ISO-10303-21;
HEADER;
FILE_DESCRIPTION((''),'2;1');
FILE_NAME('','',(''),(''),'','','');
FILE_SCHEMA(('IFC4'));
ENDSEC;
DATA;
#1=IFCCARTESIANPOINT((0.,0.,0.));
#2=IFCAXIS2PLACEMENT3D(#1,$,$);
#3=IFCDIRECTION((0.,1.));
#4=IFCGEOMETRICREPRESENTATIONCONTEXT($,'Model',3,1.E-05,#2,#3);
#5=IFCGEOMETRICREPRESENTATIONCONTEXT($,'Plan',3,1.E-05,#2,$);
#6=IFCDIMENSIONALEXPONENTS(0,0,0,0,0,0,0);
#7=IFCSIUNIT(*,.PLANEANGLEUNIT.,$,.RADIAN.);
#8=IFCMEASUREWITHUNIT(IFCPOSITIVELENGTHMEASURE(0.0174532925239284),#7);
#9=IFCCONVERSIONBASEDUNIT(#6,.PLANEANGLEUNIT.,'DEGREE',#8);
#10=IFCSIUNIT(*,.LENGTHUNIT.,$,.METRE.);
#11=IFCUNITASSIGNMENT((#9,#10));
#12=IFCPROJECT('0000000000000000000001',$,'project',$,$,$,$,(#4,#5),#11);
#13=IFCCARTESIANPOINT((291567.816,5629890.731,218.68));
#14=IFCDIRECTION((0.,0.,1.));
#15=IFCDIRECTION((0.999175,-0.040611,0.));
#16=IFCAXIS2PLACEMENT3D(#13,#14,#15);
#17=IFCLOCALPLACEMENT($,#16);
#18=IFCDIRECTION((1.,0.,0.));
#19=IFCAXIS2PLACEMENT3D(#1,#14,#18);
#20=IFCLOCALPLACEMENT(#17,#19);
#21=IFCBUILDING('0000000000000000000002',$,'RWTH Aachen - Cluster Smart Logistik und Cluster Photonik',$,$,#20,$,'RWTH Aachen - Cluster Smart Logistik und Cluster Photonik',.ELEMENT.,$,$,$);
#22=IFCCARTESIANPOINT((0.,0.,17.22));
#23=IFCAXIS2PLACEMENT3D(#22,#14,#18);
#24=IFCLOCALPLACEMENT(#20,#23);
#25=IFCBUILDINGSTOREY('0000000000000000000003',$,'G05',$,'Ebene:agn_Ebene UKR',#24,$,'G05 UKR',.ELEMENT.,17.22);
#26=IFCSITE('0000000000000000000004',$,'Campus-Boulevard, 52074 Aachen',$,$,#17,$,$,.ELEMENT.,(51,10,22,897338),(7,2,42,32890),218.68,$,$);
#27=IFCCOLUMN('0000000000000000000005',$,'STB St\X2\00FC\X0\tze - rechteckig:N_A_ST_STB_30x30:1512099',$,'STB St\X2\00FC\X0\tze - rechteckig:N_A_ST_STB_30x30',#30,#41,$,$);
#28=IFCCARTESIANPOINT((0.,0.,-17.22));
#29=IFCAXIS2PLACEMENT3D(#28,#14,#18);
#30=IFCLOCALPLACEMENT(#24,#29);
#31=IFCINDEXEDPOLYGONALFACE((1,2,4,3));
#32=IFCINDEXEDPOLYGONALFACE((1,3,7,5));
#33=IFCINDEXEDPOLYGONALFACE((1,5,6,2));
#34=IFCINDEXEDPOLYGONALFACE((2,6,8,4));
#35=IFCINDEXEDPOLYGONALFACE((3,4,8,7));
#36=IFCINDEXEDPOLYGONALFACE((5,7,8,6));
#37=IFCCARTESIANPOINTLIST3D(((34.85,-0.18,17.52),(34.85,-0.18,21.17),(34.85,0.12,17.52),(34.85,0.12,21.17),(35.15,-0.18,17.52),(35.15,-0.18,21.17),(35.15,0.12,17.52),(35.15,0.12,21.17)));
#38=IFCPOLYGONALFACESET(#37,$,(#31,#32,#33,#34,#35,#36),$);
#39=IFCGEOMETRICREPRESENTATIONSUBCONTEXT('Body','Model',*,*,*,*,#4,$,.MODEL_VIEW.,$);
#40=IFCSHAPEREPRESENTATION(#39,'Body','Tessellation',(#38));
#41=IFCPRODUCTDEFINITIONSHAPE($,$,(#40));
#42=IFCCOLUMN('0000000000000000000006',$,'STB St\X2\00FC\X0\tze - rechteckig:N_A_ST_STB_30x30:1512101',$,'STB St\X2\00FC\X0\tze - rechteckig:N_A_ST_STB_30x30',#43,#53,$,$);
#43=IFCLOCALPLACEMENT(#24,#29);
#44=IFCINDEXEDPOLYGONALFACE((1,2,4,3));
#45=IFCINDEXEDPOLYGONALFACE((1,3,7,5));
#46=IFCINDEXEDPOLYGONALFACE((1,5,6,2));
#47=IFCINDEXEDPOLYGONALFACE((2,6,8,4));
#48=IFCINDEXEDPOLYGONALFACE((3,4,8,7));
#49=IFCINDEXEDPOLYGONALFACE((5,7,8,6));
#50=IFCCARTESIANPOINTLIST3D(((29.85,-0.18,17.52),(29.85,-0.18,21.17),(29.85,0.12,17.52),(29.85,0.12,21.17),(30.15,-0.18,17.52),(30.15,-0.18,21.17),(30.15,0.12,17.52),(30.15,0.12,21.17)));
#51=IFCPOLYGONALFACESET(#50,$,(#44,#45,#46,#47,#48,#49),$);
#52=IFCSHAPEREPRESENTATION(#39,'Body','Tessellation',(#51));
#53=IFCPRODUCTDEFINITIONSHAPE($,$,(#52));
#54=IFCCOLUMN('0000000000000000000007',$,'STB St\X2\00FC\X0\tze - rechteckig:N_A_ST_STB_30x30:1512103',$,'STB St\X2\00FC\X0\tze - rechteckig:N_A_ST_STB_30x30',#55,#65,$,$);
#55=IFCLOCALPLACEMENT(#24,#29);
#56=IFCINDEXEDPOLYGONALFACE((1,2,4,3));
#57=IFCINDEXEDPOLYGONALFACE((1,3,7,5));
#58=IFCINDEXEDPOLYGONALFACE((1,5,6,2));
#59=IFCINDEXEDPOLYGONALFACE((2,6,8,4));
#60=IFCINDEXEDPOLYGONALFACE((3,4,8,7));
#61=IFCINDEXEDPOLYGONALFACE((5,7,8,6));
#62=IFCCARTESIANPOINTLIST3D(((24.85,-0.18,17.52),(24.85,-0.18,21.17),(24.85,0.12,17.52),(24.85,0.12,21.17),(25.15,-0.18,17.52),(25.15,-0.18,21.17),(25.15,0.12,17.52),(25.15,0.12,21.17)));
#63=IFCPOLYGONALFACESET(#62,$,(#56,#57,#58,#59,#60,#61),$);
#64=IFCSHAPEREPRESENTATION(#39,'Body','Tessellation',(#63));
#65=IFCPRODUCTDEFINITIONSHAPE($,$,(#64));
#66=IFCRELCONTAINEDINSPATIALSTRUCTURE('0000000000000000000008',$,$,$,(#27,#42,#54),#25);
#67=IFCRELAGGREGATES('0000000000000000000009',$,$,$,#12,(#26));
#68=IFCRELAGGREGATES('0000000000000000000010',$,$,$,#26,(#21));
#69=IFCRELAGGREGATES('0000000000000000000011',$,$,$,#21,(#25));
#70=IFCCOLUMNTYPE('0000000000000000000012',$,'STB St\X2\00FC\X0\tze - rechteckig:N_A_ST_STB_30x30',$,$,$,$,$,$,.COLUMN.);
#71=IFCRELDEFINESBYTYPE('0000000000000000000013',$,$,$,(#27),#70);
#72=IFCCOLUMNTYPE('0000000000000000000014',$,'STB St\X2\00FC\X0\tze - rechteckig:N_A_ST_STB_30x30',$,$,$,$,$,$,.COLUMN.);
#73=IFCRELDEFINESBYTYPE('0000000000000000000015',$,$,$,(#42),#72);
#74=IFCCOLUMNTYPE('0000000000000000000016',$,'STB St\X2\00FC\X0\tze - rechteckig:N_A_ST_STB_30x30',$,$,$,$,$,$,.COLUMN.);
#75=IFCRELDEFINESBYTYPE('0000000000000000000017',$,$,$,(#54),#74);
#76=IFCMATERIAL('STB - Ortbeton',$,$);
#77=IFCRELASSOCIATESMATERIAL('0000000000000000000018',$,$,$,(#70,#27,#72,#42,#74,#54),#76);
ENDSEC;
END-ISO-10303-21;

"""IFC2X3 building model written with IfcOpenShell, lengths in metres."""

from ifc_helpers import new_model, entity, si_unit, converted_unit, direction, frame, origin, origin_with_axes, origin_2d_with_axis, place, context, subcontext, project, spatial, rectangle, extrude, source, transform, mapped, material, type_object, element, save


model = new_model("IFC2X3")

# Units and contexts
model_context = context("Model", 3, precision=1e-05, world=origin(), true_north=direction((0.0, 1.0)))
plan_context = context("Plan", 3, precision=1e-05, world=origin())
body_context = subcontext(model_context, "Body", "Model", "MODEL_VIEW")
ifc_project = project(units=[converted_unit("PLANEANGLEUNIT", "DEGREE", entity("IfcPositiveLengthMeasure", 0.0174532925239284), si_unit("PLANEANGLEUNIT", "RADIAN"), dimensions=[0, 0, 0, 0, 0, 0, 0]), si_unit("LENGTHUNIT", "METRE")], contexts=[model_context, plan_context])

# Site, building, storey
site_placement = place(None, frame((291567.816, 5629890.731, 218.68), z_axis=(0.0, 0.0, 1.0), x_axis=(0.999175, -0.040611, 0.0)))
site = spatial("IfcSite", under=ifc_project, at=site_placement, Name="Campus-Boulevard, 52074 Aachen", CompositionType="ELEMENT", RefLatitude=(51, 10, 22, 897338), RefLongitude=(7, 2, 42, 32890), RefElevation=218.68)
building_placement = place(site_placement, origin_with_axes())
building = spatial("IfcBuilding", under=site, at=building_placement, Name="RWTH Aachen - Cluster Smart Logistik und Cluster Photonik", LongName="RWTH Aachen - Cluster Smart Logistik und Cluster Photonik", CompositionType="ELEMENT")
storey_placement = place(building_placement, frame((0.0, 0.0, 17.22), z_axis=(0.0, 0.0, 1.0), x_axis=(1.0, 0.0, 0.0)))
storey = spatial("IfcBuildingStorey", under=building, at=storey_placement, Name="G05", ObjectType="Ebene:agn_Ebene UKR", LongName="G05 UKR", CompositionType="ELEMENT", Elevation=17.22)

# Columns
ifc_material = material(Name="STB - Ortbeton")
column_type_1 = type_object("IfcColumnType", Name="STB Stütze - rechteckig:N_A_ST_STB_30x30", PredefinedType="COLUMN", material=ifc_material)
shared_shape_1 = source(origin(), body_context, "Body", "SweptSolid", [
    extrude(rectangle(XDim=0.3, YDim=0.3, at=origin_2d_with_axis()), frame((35.0, -0.03, 17.52), z_axis=(0.0, 0.0, 1.0), x_axis=(0.0, -1.0, 0.0)), (0.0, 0.0, 1.0), 3.65),
])
column_1_placement = place(storey_placement, frame((0.0, 0.0, -17.22), z_axis=(0.0, 0.0, 1.0), x_axis=(1.0, 0.0, 0.0)))
element("IfcColumn", 1, at=column_1_placement, inside=storey, type_object=column_type_1, material=ifc_material, Name="STB Stütze - rechteckig:N_A_ST_STB_30x30:1512099", ObjectType="STB Stütze - rechteckig:N_A_ST_STB_30x30", context=body_context, shape_type="MappedRepresentation", body=[
    mapped(shared_shape_1, transform((0.0, 0.0, 0.0), scale=1.0)),
])
column_type_2 = type_object("IfcColumnType", Name="STB Stütze - rechteckig:N_A_ST_STB_30x30", PredefinedType="COLUMN", material=ifc_material)
shared_shape_2 = source(origin(), body_context, "Body", "SweptSolid", [
    extrude(rectangle(XDim=0.3, YDim=0.3, at=origin_2d_with_axis()), frame((30.0, -0.03, 17.52), z_axis=(0.0, 0.0, 1.0), x_axis=(0.0, -1.0, 0.0)), (0.0, 0.0, 1.0), 3.65),
])
column_2_placement = place(storey_placement, frame((0.0, 0.0, -17.22), z_axis=(0.0, 0.0, 1.0), x_axis=(1.0, 0.0, 0.0)))
element("IfcColumn", 2, at=column_2_placement, inside=storey, type_object=column_type_2, material=ifc_material, Name="STB Stütze - rechteckig:N_A_ST_STB_30x30:1512101", ObjectType="STB Stütze - rechteckig:N_A_ST_STB_30x30", context=body_context, shape_type="MappedRepresentation", body=[
    mapped(shared_shape_2, transform((0.0, 0.0, 0.0), scale=1.0)),
])
column_type_3 = type_object("IfcColumnType", Name="STB Stütze - rechteckig:N_A_ST_STB_30x30", PredefinedType="COLUMN", material=ifc_material)
shared_shape_3 = source(origin(), body_context, "Body", "SweptSolid", [
    extrude(rectangle(XDim=0.3, YDim=0.3, at=origin_2d_with_axis()), frame((25.0, -0.03, 17.52), z_axis=(0.0, 0.0, 1.0), x_axis=(0.0, -1.0, 0.0)), (0.0, 0.0, 1.0), 3.65),
])
column_3_placement = place(storey_placement, frame((0.0, 0.0, -17.22), z_axis=(0.0, 0.0, 1.0), x_axis=(1.0, 0.0, 0.0)))
element("IfcColumn", 3, at=column_3_placement, inside=storey, type_object=column_type_3, material=ifc_material, Name="STB Stütze - rechteckig:N_A_ST_STB_30x30:1512103", ObjectType="STB Stütze - rechteckig:N_A_ST_STB_30x30", context=body_context, shape_type="MappedRepresentation", body=[
    mapped(shared_shape_3, transform((0.0, 0.0, 0.0), scale=1.0)),
])

save(model, "model.ifc")
